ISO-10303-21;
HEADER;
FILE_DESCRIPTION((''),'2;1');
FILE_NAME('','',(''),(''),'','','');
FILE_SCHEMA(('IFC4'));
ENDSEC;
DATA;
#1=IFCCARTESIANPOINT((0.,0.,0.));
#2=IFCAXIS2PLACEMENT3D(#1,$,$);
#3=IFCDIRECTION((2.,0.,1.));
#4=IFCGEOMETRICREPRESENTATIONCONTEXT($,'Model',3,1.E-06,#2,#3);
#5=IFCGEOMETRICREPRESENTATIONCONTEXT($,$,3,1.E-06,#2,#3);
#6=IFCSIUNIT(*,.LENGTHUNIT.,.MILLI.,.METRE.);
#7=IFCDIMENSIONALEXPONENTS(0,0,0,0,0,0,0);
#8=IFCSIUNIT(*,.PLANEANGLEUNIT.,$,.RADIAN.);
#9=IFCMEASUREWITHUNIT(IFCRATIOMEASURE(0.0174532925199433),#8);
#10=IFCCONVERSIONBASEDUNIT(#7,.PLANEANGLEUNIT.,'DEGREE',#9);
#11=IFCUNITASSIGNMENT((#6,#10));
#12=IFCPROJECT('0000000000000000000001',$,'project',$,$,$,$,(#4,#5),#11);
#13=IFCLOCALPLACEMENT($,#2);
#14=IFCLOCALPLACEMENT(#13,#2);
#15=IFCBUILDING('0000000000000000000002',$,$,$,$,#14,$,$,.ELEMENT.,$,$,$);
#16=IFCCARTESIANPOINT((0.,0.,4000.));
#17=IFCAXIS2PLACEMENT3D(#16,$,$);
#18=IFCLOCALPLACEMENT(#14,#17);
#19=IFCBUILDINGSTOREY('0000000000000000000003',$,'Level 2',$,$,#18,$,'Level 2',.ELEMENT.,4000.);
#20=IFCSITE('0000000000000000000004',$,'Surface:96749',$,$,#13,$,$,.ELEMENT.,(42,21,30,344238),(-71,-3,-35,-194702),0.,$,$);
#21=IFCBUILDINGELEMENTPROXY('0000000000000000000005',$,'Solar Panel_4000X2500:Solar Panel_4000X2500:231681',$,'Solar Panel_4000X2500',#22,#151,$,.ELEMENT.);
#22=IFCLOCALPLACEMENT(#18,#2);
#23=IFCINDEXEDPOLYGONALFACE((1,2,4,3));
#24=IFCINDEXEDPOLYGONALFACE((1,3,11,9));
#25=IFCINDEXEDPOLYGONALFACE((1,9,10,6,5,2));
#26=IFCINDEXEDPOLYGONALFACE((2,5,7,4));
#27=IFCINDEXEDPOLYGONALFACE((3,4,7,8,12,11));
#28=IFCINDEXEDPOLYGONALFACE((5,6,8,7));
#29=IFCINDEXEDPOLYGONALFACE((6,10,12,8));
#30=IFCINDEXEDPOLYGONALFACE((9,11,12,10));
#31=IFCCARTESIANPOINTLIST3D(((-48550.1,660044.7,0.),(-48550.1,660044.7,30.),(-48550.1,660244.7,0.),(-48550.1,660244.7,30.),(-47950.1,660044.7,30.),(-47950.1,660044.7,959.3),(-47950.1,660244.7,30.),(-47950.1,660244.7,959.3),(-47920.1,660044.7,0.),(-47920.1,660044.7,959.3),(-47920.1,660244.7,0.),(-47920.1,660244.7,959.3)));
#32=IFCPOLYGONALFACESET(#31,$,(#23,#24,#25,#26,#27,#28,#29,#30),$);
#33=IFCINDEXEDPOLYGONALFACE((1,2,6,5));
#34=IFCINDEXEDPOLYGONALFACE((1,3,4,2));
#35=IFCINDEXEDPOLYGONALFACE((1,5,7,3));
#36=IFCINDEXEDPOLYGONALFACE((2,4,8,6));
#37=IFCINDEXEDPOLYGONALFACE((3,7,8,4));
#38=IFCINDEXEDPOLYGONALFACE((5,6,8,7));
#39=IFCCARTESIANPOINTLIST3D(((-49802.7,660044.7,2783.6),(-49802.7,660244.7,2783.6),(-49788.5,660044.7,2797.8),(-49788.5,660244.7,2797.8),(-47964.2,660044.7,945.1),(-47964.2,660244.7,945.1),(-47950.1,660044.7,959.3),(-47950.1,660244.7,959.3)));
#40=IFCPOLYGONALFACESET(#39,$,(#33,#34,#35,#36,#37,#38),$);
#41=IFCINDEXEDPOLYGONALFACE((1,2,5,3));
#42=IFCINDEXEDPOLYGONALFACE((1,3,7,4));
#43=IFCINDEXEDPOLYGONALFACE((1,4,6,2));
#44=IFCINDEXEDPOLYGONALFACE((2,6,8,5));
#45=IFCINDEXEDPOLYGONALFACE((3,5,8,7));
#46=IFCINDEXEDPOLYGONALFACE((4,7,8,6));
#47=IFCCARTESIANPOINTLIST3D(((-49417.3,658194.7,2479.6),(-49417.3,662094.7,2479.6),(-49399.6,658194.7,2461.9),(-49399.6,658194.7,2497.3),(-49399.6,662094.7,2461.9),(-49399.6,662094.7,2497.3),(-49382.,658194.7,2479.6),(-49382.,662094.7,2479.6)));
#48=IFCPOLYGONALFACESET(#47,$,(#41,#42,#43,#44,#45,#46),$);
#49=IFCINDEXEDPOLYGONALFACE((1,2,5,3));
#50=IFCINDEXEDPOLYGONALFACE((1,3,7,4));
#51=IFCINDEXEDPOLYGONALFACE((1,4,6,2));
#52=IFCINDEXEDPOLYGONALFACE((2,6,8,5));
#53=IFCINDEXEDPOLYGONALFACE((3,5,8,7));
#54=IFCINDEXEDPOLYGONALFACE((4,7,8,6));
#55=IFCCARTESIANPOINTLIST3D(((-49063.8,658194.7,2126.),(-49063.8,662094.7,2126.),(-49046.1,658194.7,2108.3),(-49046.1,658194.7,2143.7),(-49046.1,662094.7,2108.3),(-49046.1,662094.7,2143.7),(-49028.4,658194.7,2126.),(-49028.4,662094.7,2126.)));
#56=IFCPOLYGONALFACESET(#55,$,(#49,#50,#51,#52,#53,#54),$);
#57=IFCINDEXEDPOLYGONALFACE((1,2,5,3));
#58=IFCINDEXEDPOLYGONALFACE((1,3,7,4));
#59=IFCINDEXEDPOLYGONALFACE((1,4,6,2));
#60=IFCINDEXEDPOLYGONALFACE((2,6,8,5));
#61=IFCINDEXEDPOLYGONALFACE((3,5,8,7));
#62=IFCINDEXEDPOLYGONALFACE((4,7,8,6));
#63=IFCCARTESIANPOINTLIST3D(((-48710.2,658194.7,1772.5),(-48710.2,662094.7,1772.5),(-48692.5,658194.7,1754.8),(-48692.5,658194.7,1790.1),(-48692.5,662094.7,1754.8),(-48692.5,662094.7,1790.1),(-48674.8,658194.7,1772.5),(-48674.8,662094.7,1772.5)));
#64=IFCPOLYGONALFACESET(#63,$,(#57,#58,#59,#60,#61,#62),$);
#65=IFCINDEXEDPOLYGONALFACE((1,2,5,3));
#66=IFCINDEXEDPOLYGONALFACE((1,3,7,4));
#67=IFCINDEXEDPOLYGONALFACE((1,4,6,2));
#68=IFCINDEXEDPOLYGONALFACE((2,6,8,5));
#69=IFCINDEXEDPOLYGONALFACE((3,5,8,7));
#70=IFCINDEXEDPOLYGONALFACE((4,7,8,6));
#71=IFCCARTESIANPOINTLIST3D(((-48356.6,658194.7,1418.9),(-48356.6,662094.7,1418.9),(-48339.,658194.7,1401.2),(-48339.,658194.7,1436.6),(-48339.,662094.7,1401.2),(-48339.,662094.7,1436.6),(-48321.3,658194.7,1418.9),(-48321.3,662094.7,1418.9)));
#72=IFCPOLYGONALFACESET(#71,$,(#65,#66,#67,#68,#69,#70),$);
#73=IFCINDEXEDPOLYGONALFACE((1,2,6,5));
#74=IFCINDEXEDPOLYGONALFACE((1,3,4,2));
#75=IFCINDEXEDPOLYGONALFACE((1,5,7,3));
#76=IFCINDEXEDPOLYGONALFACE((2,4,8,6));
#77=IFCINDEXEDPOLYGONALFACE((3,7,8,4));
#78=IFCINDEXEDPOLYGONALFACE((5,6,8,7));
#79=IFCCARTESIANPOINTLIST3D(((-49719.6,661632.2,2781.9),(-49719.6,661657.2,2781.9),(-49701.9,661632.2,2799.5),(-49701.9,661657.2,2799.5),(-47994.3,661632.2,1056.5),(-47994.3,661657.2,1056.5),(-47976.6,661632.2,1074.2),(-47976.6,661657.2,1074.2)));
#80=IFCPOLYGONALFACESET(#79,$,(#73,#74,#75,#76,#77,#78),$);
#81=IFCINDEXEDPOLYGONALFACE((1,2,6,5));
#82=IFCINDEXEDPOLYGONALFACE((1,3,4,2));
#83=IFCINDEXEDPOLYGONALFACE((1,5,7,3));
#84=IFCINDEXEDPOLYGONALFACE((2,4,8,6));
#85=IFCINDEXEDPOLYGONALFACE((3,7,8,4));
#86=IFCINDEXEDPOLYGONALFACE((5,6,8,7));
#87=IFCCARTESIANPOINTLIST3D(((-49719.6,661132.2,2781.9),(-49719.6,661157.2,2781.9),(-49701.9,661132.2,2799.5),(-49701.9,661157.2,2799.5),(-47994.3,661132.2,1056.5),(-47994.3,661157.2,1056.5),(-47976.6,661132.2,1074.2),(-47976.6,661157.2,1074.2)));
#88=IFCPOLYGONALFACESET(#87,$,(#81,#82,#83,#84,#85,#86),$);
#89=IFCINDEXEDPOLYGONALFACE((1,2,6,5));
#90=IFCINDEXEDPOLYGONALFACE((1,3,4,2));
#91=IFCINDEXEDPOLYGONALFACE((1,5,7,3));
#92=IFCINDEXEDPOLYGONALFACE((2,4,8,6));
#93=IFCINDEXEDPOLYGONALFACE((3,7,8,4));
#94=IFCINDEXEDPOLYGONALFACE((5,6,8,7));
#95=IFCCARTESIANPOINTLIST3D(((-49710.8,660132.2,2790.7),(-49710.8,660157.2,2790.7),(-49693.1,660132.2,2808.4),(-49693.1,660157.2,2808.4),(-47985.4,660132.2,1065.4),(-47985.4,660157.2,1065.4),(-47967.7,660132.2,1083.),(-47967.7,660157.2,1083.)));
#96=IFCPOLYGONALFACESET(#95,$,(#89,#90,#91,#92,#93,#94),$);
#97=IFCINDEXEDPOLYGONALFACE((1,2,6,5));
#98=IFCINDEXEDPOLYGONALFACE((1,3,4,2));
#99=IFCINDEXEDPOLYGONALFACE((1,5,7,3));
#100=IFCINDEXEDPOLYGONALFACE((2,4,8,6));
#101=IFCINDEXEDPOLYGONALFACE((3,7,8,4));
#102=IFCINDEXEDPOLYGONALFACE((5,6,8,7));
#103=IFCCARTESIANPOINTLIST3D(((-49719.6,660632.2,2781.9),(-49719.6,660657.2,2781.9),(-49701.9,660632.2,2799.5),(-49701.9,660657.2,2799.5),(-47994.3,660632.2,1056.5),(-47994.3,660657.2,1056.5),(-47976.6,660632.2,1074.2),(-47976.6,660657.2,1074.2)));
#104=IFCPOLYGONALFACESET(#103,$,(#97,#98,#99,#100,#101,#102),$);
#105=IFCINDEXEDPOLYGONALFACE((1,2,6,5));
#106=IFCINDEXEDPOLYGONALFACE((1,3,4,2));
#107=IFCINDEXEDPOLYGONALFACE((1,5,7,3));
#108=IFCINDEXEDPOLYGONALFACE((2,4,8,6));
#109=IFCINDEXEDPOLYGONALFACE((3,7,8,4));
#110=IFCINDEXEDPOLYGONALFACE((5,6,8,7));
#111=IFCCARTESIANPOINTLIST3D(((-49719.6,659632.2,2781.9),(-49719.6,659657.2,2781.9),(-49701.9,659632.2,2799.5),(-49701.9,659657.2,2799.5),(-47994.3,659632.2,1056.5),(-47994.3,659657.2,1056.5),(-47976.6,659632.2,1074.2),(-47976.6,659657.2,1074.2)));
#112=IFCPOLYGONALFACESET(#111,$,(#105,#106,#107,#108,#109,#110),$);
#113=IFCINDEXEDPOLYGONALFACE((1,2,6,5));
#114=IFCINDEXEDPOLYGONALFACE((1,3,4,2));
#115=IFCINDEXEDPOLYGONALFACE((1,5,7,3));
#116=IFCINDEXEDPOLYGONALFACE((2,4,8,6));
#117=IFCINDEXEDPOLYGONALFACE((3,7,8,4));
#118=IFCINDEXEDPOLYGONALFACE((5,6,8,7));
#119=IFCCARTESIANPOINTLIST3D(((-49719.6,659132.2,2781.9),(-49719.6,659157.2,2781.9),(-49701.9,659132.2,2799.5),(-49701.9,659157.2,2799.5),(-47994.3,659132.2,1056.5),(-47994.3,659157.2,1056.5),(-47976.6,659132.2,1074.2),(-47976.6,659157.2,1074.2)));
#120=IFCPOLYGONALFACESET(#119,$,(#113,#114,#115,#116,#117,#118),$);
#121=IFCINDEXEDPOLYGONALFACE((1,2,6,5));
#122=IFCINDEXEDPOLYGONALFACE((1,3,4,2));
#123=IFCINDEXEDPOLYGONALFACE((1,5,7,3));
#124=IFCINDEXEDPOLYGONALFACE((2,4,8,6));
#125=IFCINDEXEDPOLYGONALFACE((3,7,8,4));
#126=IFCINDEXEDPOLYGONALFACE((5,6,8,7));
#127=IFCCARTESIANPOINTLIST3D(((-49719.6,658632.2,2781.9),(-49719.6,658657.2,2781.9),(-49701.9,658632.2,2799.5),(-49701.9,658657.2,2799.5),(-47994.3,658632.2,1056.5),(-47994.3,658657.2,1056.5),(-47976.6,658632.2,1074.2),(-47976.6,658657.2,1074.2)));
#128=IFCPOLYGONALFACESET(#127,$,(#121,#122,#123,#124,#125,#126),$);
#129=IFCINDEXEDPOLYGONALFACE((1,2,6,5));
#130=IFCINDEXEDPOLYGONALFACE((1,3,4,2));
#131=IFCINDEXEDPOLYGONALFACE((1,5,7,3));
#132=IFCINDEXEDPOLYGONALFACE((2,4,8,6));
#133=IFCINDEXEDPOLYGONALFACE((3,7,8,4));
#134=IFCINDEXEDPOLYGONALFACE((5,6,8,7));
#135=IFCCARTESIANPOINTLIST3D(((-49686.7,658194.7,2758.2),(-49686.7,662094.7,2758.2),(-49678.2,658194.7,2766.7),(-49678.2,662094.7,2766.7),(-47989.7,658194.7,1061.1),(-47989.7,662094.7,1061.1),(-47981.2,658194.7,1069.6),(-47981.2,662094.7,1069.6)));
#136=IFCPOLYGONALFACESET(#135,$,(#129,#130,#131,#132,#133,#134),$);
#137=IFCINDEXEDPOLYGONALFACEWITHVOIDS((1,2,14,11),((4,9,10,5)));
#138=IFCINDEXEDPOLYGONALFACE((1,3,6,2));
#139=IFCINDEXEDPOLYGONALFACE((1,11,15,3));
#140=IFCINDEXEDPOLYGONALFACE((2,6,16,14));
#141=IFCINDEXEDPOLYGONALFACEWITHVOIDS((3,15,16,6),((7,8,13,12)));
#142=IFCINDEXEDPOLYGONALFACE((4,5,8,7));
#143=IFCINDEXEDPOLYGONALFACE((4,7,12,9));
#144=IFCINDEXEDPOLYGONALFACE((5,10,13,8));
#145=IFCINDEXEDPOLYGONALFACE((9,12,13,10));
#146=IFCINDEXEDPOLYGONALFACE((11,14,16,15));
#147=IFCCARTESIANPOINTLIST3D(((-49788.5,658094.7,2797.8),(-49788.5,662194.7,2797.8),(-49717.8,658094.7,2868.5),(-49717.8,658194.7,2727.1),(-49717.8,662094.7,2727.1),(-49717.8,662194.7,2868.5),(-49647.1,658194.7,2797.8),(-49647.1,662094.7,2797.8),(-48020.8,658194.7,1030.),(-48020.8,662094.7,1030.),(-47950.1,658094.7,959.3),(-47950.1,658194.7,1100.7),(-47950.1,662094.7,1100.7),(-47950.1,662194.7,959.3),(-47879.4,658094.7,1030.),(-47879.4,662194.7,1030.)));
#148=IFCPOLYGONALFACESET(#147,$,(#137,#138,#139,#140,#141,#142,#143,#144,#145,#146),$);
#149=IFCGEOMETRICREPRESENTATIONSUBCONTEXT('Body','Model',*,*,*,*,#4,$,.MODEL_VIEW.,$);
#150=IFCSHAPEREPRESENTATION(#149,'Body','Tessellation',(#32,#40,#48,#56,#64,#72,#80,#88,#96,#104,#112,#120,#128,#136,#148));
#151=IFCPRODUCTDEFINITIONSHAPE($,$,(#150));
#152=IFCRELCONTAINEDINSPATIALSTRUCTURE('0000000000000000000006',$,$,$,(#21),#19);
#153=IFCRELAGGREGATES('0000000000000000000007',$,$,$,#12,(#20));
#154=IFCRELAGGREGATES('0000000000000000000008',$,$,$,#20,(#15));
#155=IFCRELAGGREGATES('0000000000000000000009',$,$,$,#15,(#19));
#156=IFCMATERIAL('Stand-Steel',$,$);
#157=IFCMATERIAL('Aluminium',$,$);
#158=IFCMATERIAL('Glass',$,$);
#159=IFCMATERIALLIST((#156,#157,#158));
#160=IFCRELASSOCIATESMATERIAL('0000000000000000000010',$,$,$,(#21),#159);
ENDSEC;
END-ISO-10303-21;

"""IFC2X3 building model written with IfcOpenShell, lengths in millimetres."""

from ifc_helpers import new_model, entity, si_unit, converted_unit, direction, frame, frame_2d, origin, origin_2d_with_axis, place, context, subcontext, project, spatial, polyline, rectangle, outline, extrude, source, transform, mapped, material, material_list, element, save


model = new_model("IFC2X3")

# Units and contexts
model_context = context("Model", 3, precision=1e-06, world=origin(), true_north=direction((2.0, 0.0, 1.0)))
context_of_model = context(None, 3, precision=1e-06, world=origin(), true_north=direction((2.0, 0.0, 1.0)))
body_context = subcontext(model_context, "Body", "Model", "MODEL_VIEW")
ifc_project = project(units=[si_unit("LENGTHUNIT", "METRE", prefix="MILLI"), converted_unit("PLANEANGLEUNIT", "DEGREE", entity("IfcRatioMeasure", 0.0174532925199433), si_unit("PLANEANGLEUNIT", "RADIAN"), dimensions=[0, 0, 0, 0, 0, 0, 0])], contexts=[model_context, context_of_model])

# Site, building, storey
site_placement = place(None, origin())
site = spatial("IfcSite", under=ifc_project, at=site_placement, Name="Surface:96749", CompositionType="ELEMENT", RefLatitude=(42, 21, 30, 344238), RefLongitude=(-71, -3, -35, -194702), RefElevation=0.0)
building_placement = place(site_placement, origin())
building = spatial("IfcBuilding", under=site, at=building_placement, CompositionType="ELEMENT")
storey_placement = place(building_placement, frame((0.0, 0.0, 4000.0)))
storey = spatial("IfcBuildingStorey", under=building, at=storey_placement, Name="Level 2", LongName="Level 2", CompositionType="ELEMENT", Elevation=4000.0)

# Building element proxy
ifc_material_1 = material(Name="Stand-Steel")
ifc_material_2 = material(Name="Aluminium")
ifc_material_3 = material(Name="Glass")
shared_shape = source(origin(), body_context, "Body", "SweptSolid", [
    extrude(outline(polyline([(-629.5, -220.0), (329.8, -220.0), (329.8, 410.0), (299.8, 410.0), (299.8, -190.0), (-629.5, -190.0), (-629.5, -220.0)])), frame((-190.0, -100.0, 299.8), z_axis=(0.0, 1.0, 0.0), x_axis=(0.0, 0.0, -1.0)), (0.0, 0.0, 1.0), 200.0),
    extrude(rectangle(XDim=20.0, YDim=200.0, at=frame_2d((0.0, 0.0), x_axis=(0.0, 1.0))), frame((-7.1, 0.0, 922.2), z_axis=(-0.707107, 0.0, 0.707107), x_axis=(0.0, 1.0, 0.0)), (0.0, 0.0, 1.0), 2600.0),
    extrude(rectangle(XDim=25.0, YDim=25.0, at=frame_2d((0.0, 0.0), x_axis=(1.0, 0.0))), frame((-1449.6, -1950.0, 2449.6), z_axis=(0.0, 1.0, 0.0), x_axis=(-0.707107, 0.0, -0.707107)), (0.0, 0.0, 1.0), 3900.0),
    extrude(rectangle(XDim=25.0, YDim=25.0, at=origin_2d_with_axis()), frame((-1096.0, -1950.0, 2096.0), z_axis=(0.0, 1.0, 0.0), x_axis=(-0.707107, 0.0, -0.707107)), (0.0, 0.0, 1.0), 3900.0),
    extrude(rectangle(XDim=25.0, YDim=25.0, at=origin_2d_with_axis()), frame((-742.5, -1950.0, 1742.5), z_axis=(0.0, 1.0, 0.0), x_axis=(-0.707107, 0.0, -0.707107)), (0.0, 0.0, 1.0), 3900.0),
    extrude(rectangle(XDim=25.0, YDim=25.0, at=frame_2d((0.0, 0.0), x_axis=(1.0, 0.0))), frame((-388.9, -1950.0, 1388.9), z_axis=(0.0, 1.0, 0.0), x_axis=(-0.707107, 0.0, -0.707107)), (0.0, 0.0, 1.0), 3900.0),
    extrude(rectangle(XDim=25.0, YDim=25.0, at=frame_2d((0.0, 0.0), x_axis=(0.0, 1.0))), frame((-35.4, 1500.0, 1035.4), z_axis=(-0.707107, 0.0, 0.707107), x_axis=(0.0, 1.0, 0.0)), (0.0, 0.0, 1.0), 2440.0),
    extrude(rectangle(XDim=25.0, YDim=25.0, at=frame_2d((0.0, 0.0), x_axis=(0.0, 1.0))), frame((-35.4, 1000.0, 1035.4), z_axis=(-0.707107, 0.0, 0.707107), x_axis=(0.0, 1.0, 0.0)), (0.0, 0.0, 1.0), 2440.0),
    extrude(rectangle(XDim=25.0, YDim=25.0, at=frame_2d((0.0, 0.0), x_axis=(0.0, 1.0))), frame((-26.5, 0.0, 1044.2), z_axis=(-0.707107, 0.0, 0.707107), x_axis=(0.0, -1.0, 0.0)), (0.0, 0.0, 1.0), 2440.0),
    extrude(rectangle(XDim=25.0, YDim=25.0, at=frame_2d((0.0, 0.0), x_axis=(0.0, 1.0))), frame((-35.4, 500.0, 1035.4), z_axis=(-0.707107, 0.0, 0.707107), x_axis=(0.0, 1.0, 0.0)), (0.0, 0.0, 1.0), 2440.0),
    extrude(rectangle(XDim=25.0, YDim=25.0, at=frame_2d((0.0, 0.0), x_axis=(0.0, 1.0))), frame((-35.4, -500.0, 1035.4), z_axis=(-0.707107, 0.0, 0.707107), x_axis=(0.0, 1.0, 0.0)), (0.0, 0.0, 1.0), 2440.0),
    extrude(rectangle(XDim=25.0, YDim=25.0, at=frame_2d((0.0, 0.0), x_axis=(0.0, 1.0))), frame((-35.4, -1000.0, 1035.4), z_axis=(-0.707107, 0.0, 0.707107), x_axis=(0.0, 1.0, 0.0)), (0.0, 0.0, 1.0), 2440.0),
    extrude(rectangle(XDim=25.0, YDim=25.0, at=frame_2d((0.0, 0.0), x_axis=(0.0, 1.0))), frame((-35.4, -1500.0, 1035.4), z_axis=(-0.707107, 0.0, 0.707107), x_axis=(0.0, 1.0, 0.0)), (0.0, 0.0, 1.0), 2440.0),
    extrude(rectangle(XDim=2400.0, YDim=12.0, at=frame_2d((0.0, 0.0), x_axis=(1.0, 0.0))), frame((-883.9, -1950.0, 1883.9), z_axis=(0.0, 1.0, 0.0), x_axis=(0.707107, 0.0, -0.707107)), (0.0, 0.0, 1.0), 3900.0),
    extrude(outline(polyline([(-2050.0, -1300.0), (2050.0, -1300.0), (2050.0, 1300.0), (-2050.0, 1300.0), (-2050.0, -1300.0)]), holes=[polyline([(1950.0, -1200.0), (-1950.0, -1200.0), (-1950.0, 1200.0), (1950.0, 1200.0), (1950.0, -1200.0)])]), frame((-919.2, 0.0, 1848.5), z_axis=(0.707107, 0.0, 0.707107), x_axis=(0.0, 1.0, 0.0)), (0.0, 0.0, 1.0), 100.0),
])
ifc_material_list_1 = material_list([ifc_material_1, ifc_material_2, ifc_material_3])
proxy_1_placement = place(storey_placement, frame((-47950.1, 660144.7, 30.0)))
element("IfcBuildingElementProxy", 1, at=proxy_1_placement, inside=storey, material=ifc_material_list_1, Name="Solar Panel_4000X2500:Solar Panel_4000X2500:231681", ObjectType="Solar Panel_4000X2500", CompositionType="ELEMENT", context=body_context, shape_type="MappedRepresentation", body=[
    mapped(shared_shape, transform((0.0, 0.0, 0.0), scale=1.0)),
])

save(model, "model.ifc")
